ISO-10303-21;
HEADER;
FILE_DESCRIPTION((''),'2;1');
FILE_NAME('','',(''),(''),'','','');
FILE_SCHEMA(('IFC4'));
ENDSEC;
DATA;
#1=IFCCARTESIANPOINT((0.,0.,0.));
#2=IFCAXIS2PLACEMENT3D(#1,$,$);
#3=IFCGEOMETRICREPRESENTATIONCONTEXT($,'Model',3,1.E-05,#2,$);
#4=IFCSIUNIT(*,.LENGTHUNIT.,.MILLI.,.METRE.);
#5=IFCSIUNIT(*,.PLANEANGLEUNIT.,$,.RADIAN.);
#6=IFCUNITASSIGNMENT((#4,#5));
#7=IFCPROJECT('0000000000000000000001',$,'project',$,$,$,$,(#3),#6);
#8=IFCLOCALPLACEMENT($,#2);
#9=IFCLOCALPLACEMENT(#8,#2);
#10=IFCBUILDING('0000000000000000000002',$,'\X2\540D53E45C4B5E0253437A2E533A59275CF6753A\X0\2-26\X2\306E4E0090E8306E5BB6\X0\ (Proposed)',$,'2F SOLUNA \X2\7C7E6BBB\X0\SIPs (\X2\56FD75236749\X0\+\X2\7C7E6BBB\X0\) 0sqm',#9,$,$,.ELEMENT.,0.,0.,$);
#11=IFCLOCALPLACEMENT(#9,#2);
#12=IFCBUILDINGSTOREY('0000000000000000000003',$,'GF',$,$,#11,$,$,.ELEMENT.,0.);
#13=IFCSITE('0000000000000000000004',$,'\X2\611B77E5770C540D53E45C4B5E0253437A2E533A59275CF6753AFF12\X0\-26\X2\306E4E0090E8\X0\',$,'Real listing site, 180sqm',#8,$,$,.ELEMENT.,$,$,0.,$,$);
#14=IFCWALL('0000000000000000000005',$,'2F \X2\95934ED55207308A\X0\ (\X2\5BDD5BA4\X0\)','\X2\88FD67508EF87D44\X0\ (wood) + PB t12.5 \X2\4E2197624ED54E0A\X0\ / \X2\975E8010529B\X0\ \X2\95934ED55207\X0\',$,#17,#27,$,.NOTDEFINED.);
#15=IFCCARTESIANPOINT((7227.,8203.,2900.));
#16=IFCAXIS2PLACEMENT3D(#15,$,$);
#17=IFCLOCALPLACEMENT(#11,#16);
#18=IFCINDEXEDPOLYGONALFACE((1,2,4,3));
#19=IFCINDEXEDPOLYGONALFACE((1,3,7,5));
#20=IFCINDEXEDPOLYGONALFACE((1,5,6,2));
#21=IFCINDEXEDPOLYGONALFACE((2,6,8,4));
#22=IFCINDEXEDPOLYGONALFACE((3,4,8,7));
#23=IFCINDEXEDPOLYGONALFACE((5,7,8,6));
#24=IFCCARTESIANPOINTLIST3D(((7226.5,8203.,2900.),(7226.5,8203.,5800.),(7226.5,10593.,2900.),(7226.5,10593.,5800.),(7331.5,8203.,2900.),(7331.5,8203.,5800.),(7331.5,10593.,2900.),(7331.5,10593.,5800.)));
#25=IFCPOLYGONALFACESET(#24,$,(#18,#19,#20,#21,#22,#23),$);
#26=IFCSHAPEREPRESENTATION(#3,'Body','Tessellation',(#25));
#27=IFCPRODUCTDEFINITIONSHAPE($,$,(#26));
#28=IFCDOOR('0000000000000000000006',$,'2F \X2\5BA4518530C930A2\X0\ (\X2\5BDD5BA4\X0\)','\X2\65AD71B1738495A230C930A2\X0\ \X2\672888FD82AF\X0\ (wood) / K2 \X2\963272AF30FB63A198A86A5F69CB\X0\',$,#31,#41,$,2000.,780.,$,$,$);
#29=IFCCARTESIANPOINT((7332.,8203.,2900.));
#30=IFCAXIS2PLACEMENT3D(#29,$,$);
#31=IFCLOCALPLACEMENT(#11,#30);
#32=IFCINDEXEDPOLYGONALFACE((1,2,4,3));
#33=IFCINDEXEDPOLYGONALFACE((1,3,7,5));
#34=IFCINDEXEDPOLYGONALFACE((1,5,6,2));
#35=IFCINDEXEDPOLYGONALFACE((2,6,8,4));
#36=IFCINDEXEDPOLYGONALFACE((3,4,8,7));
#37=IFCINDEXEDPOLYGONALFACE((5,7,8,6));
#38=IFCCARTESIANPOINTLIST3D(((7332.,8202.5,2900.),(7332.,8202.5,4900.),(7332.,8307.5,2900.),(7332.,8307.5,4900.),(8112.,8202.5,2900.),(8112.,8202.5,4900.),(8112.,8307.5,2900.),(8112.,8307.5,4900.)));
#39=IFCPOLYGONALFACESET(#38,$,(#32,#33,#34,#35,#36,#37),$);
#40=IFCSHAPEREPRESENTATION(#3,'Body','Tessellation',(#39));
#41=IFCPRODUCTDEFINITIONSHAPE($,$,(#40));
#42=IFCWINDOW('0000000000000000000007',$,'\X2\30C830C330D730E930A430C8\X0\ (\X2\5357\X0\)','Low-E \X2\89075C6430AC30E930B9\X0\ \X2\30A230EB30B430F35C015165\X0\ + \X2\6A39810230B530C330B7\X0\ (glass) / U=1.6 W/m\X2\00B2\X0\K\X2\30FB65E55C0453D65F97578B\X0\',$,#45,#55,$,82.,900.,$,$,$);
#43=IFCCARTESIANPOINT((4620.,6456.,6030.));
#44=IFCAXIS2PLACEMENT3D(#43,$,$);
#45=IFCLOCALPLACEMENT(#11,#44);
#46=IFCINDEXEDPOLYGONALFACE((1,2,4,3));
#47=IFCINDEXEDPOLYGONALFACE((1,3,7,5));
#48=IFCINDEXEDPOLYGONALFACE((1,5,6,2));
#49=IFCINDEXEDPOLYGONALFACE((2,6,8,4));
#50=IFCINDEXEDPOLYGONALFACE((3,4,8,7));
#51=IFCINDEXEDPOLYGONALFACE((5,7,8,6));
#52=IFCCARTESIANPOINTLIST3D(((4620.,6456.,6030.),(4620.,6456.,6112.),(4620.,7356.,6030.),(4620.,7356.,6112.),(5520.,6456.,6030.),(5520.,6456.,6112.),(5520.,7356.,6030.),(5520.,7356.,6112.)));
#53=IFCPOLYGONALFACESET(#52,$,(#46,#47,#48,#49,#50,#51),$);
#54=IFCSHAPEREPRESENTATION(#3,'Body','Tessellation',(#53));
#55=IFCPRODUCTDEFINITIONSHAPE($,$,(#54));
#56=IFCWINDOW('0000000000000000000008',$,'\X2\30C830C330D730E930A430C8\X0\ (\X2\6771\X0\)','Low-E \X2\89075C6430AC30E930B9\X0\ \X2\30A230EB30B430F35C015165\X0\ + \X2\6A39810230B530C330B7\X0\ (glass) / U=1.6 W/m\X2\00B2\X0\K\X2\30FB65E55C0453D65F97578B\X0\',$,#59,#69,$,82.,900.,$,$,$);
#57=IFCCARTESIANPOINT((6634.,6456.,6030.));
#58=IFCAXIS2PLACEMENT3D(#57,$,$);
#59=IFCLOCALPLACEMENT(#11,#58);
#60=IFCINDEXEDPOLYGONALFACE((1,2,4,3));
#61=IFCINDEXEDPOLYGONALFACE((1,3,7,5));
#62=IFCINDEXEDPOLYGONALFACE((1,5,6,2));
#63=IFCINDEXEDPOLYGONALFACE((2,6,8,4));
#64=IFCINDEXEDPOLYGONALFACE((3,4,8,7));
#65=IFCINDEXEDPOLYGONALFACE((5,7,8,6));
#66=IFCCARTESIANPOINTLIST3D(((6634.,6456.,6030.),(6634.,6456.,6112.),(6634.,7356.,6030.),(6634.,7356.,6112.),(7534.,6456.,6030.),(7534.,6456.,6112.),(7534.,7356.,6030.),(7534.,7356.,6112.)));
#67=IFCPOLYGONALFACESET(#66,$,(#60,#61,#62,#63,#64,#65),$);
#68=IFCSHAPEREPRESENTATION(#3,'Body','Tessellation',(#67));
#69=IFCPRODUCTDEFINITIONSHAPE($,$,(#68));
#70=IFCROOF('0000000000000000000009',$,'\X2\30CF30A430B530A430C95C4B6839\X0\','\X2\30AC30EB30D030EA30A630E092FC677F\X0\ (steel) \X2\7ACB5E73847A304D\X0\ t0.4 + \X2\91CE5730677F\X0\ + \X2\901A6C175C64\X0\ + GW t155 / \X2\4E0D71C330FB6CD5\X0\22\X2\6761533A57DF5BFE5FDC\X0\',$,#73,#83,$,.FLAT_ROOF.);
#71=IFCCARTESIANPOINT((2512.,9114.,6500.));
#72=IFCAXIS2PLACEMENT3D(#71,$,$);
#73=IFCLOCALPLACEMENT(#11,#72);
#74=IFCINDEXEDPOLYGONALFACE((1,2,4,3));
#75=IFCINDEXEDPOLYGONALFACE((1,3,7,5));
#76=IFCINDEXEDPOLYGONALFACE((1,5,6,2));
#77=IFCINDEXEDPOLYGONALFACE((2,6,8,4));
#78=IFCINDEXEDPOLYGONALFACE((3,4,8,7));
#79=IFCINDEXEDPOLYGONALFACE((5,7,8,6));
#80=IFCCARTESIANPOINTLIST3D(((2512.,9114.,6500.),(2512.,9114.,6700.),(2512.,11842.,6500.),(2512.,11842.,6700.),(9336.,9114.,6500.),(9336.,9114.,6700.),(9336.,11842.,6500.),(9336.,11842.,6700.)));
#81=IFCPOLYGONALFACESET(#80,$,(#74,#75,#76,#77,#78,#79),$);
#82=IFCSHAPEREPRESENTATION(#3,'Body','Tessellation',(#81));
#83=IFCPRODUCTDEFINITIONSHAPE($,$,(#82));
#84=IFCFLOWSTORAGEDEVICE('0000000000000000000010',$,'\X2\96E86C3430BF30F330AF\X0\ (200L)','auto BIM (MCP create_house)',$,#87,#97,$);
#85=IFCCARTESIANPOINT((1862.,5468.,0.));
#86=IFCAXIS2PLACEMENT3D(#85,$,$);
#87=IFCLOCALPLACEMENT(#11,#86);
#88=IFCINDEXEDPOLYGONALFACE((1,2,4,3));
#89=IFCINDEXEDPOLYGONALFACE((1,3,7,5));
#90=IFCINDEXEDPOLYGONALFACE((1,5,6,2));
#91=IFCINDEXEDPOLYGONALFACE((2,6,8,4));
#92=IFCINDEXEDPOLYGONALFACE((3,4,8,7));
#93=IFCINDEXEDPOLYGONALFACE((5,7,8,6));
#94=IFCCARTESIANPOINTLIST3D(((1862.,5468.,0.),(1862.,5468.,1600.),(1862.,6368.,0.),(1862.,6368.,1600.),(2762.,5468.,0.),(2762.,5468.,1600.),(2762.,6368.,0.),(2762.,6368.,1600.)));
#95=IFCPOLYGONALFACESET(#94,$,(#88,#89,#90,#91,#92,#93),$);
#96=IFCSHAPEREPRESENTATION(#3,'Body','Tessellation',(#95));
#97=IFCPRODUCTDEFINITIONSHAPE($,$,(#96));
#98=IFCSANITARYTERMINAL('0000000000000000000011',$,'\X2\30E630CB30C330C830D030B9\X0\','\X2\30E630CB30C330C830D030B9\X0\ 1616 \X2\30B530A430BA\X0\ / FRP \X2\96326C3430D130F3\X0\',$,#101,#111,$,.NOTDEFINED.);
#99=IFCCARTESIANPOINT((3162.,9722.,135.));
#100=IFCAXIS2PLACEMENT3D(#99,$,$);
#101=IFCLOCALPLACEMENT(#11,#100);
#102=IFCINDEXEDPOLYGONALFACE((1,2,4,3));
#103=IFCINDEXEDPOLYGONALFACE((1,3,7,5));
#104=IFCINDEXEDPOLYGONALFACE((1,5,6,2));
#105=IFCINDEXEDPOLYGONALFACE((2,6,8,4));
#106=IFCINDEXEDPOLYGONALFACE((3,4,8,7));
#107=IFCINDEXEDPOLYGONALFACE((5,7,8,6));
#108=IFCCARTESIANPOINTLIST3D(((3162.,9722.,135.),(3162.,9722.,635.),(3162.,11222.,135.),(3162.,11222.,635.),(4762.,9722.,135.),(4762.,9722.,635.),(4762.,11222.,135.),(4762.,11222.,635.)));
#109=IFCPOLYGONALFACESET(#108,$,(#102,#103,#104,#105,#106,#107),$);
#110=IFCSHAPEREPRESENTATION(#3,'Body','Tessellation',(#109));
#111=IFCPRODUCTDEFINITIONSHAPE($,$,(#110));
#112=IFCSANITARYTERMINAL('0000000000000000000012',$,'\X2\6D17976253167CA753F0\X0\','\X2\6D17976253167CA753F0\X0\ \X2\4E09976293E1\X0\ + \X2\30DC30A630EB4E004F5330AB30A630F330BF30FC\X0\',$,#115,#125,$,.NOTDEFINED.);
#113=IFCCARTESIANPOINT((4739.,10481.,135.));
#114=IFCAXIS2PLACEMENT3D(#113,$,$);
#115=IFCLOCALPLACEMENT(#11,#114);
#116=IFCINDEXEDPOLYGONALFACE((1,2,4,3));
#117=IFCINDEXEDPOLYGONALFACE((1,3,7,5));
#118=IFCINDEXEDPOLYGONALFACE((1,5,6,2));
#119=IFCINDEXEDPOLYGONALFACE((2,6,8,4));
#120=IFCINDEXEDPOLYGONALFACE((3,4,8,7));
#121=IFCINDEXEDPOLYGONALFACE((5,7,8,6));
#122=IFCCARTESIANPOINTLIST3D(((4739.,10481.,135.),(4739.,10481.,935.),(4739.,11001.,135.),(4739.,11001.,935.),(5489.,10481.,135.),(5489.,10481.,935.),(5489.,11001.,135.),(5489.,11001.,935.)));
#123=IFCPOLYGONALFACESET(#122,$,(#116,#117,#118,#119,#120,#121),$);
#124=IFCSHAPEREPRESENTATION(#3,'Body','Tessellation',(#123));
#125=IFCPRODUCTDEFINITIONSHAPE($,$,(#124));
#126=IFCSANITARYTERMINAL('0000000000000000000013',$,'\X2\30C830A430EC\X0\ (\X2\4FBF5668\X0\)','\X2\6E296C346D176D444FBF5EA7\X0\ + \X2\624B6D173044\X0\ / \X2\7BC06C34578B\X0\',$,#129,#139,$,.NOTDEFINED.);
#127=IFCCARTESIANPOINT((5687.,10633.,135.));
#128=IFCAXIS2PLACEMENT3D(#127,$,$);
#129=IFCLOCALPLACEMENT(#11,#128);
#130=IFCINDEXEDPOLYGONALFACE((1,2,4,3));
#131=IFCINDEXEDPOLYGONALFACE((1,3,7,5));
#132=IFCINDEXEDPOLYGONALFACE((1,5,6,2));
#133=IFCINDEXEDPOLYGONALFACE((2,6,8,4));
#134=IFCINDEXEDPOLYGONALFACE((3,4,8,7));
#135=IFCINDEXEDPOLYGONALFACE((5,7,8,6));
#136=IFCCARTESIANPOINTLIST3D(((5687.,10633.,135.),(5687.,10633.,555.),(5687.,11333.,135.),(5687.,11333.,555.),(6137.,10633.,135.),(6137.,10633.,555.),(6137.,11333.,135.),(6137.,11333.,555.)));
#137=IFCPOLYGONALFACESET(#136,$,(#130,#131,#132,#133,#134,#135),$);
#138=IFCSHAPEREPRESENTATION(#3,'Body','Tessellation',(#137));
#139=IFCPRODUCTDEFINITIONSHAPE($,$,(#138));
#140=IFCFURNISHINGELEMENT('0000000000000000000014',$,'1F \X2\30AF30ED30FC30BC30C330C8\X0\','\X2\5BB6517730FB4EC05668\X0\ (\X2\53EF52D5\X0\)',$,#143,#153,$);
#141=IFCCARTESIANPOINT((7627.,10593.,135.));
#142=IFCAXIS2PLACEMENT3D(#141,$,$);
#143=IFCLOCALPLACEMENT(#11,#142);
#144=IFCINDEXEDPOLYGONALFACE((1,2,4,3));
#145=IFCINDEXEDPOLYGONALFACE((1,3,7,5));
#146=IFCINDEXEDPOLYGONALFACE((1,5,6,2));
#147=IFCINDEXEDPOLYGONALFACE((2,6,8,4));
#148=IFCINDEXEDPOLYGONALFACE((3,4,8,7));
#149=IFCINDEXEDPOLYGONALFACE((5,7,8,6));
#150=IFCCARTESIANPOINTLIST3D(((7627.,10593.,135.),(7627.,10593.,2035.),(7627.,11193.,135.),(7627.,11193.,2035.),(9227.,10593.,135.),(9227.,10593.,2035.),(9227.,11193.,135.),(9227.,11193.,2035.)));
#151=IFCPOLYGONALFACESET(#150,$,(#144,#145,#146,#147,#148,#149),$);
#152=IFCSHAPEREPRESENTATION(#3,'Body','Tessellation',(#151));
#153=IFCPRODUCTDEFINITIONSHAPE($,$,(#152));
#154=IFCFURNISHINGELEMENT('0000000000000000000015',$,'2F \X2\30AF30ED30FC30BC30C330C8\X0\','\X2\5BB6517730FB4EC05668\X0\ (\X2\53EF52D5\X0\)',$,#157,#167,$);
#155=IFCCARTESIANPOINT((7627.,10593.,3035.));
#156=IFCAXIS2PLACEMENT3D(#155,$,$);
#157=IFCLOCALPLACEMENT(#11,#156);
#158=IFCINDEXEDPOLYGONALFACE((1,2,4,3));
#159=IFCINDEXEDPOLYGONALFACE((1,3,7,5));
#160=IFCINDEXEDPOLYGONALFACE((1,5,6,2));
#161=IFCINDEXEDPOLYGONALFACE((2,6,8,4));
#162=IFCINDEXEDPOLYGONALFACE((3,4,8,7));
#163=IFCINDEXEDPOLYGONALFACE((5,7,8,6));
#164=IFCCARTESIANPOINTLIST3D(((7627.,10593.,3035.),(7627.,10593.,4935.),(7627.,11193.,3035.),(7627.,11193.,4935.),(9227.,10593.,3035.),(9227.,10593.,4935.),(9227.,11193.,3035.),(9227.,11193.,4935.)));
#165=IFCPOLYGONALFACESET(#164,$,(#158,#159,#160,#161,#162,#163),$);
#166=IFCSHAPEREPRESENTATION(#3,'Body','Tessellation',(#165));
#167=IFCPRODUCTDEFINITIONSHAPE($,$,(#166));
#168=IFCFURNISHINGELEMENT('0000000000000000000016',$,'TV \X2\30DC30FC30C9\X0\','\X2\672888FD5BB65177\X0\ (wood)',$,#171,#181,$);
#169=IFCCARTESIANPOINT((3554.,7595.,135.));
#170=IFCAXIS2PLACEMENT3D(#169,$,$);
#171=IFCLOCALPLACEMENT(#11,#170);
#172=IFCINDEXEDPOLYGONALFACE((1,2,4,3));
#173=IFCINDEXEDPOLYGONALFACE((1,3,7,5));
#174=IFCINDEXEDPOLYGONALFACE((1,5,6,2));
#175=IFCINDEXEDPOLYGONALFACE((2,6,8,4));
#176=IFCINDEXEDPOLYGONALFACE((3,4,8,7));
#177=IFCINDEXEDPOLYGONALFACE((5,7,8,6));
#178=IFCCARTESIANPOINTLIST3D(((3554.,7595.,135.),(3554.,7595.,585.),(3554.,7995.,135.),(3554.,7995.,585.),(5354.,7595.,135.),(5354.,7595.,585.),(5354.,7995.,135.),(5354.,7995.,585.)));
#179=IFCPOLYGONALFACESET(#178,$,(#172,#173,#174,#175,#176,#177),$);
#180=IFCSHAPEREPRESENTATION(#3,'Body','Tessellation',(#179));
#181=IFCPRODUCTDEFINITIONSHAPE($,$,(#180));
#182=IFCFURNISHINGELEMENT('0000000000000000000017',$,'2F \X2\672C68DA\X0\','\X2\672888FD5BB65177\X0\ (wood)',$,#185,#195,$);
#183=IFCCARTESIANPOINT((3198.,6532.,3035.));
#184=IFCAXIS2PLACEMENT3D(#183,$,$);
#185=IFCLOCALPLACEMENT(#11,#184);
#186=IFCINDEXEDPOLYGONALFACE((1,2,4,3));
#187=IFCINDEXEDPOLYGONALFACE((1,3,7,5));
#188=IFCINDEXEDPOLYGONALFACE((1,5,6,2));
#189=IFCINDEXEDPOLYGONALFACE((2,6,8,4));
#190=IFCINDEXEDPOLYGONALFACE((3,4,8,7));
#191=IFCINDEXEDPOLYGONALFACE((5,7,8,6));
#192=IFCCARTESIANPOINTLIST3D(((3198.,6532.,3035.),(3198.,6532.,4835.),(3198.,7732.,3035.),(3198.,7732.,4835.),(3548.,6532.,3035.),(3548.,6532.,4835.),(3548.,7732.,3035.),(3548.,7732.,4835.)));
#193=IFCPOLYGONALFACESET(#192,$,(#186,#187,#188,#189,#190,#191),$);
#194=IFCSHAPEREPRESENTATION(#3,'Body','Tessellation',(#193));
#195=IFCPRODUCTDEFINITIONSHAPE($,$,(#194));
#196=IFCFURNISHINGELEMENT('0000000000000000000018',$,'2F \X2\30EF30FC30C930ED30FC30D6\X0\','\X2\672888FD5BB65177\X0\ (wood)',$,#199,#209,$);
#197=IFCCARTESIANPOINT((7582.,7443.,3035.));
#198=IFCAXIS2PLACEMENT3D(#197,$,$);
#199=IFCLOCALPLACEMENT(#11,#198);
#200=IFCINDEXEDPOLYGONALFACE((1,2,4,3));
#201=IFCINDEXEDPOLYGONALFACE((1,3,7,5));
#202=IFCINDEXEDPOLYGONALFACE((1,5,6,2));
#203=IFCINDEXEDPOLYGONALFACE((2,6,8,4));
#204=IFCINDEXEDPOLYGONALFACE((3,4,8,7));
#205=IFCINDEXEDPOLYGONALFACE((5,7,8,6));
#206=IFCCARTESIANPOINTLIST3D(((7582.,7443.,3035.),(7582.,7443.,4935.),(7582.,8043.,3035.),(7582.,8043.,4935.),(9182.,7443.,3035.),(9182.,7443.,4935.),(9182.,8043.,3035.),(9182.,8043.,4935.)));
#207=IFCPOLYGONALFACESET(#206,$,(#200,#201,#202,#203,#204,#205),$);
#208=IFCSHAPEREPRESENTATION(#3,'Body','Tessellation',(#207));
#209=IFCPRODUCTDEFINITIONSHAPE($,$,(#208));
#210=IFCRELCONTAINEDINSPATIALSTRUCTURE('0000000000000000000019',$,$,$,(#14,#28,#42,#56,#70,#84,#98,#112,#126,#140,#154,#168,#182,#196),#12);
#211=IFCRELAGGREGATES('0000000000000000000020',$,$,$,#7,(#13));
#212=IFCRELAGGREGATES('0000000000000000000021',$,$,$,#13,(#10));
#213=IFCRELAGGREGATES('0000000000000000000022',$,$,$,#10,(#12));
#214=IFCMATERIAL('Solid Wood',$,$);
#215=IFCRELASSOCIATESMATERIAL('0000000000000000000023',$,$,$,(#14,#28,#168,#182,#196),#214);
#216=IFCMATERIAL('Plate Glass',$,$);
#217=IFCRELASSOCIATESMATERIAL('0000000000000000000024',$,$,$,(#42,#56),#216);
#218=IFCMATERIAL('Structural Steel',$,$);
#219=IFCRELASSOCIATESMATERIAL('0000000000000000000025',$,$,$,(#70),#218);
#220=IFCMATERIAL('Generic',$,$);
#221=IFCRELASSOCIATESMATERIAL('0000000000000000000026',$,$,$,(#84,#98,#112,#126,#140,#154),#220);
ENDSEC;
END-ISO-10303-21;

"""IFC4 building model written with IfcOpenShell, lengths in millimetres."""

from ifc_helpers import new_model, si_unit, frame, frame_2d, origin, place, context, project, spatial, rectangle, extrude, material, element, save


model = new_model("IFC4")

# Units and contexts
model_context = context("Model", 3, precision=1e-05, world=origin())
ifc_project = project(units=[si_unit("LENGTHUNIT", "METRE", prefix="MILLI"), si_unit("PLANEANGLEUNIT", "RADIAN")], contexts=[model_context])

# Site, building, storey
site_placement = place(None, origin())
site = spatial("IfcSite", under=ifc_project, at=site_placement, Name="愛知県名古屋市千種区大島町２-26の一部", ObjectType="Real listing site, 180sqm", CompositionType="ELEMENT", RefElevation=0.0)
building_placement = place(site_placement, origin())
building = spatial("IfcBuilding", under=site, at=building_placement, Name="名古屋市千種区大島町2-26の一部の家 (Proposed)", ObjectType="2F SOLUNA 籾殻SIPs (国産杉+籾殻) 0sqm", CompositionType="ELEMENT", ElevationOfRefHeight=0.0, ElevationOfTerrain=0.0)
storey_placement = place(building_placement, origin())
storey = spatial("IfcBuildingStorey", under=building, at=storey_placement, Name="GF", CompositionType="ELEMENT", Elevation=0.0)

# Shared definitions
ifc_material_1 = material(Name="Solid Wood")
ifc_material_2 = material(Name="Plate Glass")

# Wall
wall_1_placement = place(storey_placement, frame((7227.0, 8203.0, 2900.0)))
element("IfcWall", 1, at=wall_1_placement, inside=storey, material=ifc_material_1, Name="2F 間仕切り (寝室)", Description="製材軸組 (wood) + PB t12.5 両面仕上 / 非耐力 間仕切", PredefinedType="NOTDEFINED", context=model_context, shape_type="SweptSolid", body=[
    extrude(rectangle(XDim=105.0, YDim=2390.0, at=frame_2d((52.0, 1195.0))), frame((7227.0, 8203.0, 2900.0)), (0.0, 0.0, 1.0), 2900.0),
])

# Door
door_1_placement = place(storey_placement, frame((7332.0, 8203.0, 2900.0)))
element("IfcDoor", 2, at=door_1_placement, inside=storey, material=ifc_material_1, Name="2F 室内ドア (寝室)", Description="断熱玄関ドア 木製芯 (wood) / K2 防犯・採風機構", OverallHeight=2000.0, OverallWidth=780.0, context=model_context, shape_type="SweptSolid", body=[
    extrude(rectangle(XDim=780.0, YDim=105.0, at=frame_2d((390.0, 52.0))), frame((7332.0, 8203.0, 2900.0)), (0.0, 0.0, 1.0), 2000.0),
])

# Windows
window_1_placement = place(storey_placement, frame((4620.0, 6456.0, 6030.0)))
element("IfcWindow", 3, at=window_1_placement, inside=storey, material=ifc_material_2, Name="トップライト (南)", Description="Low-E 複層ガラス アルゴン封入 + 樹脂サッシ (glass) / U=1.6 W/m²K・日射取得型", OverallHeight=82.0, OverallWidth=900.0, context=model_context, shape_type="SweptSolid", body=[
    extrude(rectangle(XDim=900.0, YDim=900.0, at=frame_2d((450.0, 450.0))), frame((4620.0, 6456.0, 6030.0)), (0.0, 0.0, 1.0), 82.0),
])
window_2_placement = place(storey_placement, frame((6634.0, 6456.0, 6030.0)))
element("IfcWindow", 4, at=window_2_placement, inside=storey, material=ifc_material_2, Name="トップライト (東)", Description="Low-E 複層ガラス アルゴン封入 + 樹脂サッシ (glass) / U=1.6 W/m²K・日射取得型", OverallHeight=82.0, OverallWidth=900.0, context=model_context, shape_type="SweptSolid", body=[
    extrude(rectangle(XDim=900.0, YDim=900.0, at=frame_2d((450.0, 450.0))), frame((6634.0, 6456.0, 6030.0)), (0.0, 0.0, 1.0), 82.0),
])

# Roof
ifc_material_3 = material(Name="Structural Steel")
roof_placement = place(storey_placement, frame((2512.0, 9114.0, 6500.0)))
element("IfcRoof", 5, at=roof_placement, inside=storey, material=ifc_material_3, Name="ハイサイド屋根", Description="ガルバリウム鋼板 (steel) 立平葺き t0.4 + 野地板 + 通気層 + GW t155 / 不燃・法22条区域対応", PredefinedType="FLAT_ROOF", context=model_context, shape_type="SweptSolid", body=[
    extrude(rectangle(XDim=6824.0, YDim=2728.0, at=frame_2d((3412.0, 1364.0))), frame((2512.0, 9114.0, 6500.0)), (0.0, 0.0, 1.0), 200.0),
])

# Flow storage device
ifc_material_4 = material(Name="Generic")
flow_storage_device_placement = place(storey_placement, frame((1862.0, 5468.0, 0.0)))
element("IfcFlowStorageDevice", 6, at=flow_storage_device_placement, inside=storey, material=ifc_material_4, Name="雨水タンク (200L)", Description="auto BIM (MCP create_house)", context=model_context, shape_type="SweptSolid", body=[
    extrude(rectangle(XDim=900.0, YDim=900.0, at=frame_2d((450.0, 450.0))), frame((1862.0, 5468.0, 0.0)), (0.0, 0.0, 1.0), 1600.0),
])

# Sanitary terminals
sanitary_terminal_1_placement = place(storey_placement, frame((3162.0, 9722.0, 135.0)))
element("IfcSanitaryTerminal", 7, at=sanitary_terminal_1_placement, inside=storey, material=ifc_material_4, Name="ユニットバス", Description="ユニットバス 1616 サイズ / FRP 防水パン", PredefinedType="NOTDEFINED", context=model_context, shape_type="SweptSolid", body=[
    extrude(rectangle(XDim=1600.0, YDim=1500.0, at=frame_2d((800.0, 750.0))), frame((3162.0, 9722.0, 135.0)), (0.0, 0.0, 1.0), 500.0),
])
sanitary_terminal_2_placement = place(storey_placement, frame((4739.0, 10481.0, 135.0)))
element("IfcSanitaryTerminal", 8, at=sanitary_terminal_2_placement, inside=storey, material=ifc_material_4, Name="洗面化粧台", Description="洗面化粧台 三面鏡 + ボウル一体カウンター", PredefinedType="NOTDEFINED", context=model_context, shape_type="SweptSolid", body=[
    extrude(rectangle(XDim=750.0, YDim=520.0, at=frame_2d((375.0, 260.0))), frame((4739.0, 10481.0, 135.0)), (0.0, 0.0, 1.0), 800.0),
])
sanitary_terminal_3_placement = place(storey_placement, frame((5687.0, 10633.0, 135.0)))
element("IfcSanitaryTerminal", 9, at=sanitary_terminal_3_placement, inside=storey, material=ifc_material_4, Name="トイレ (便器)", Description="温水洗浄便座 + 手洗い / 節水型", PredefinedType="NOTDEFINED", context=model_context, shape_type="SweptSolid", body=[
    extrude(rectangle(XDim=450.0, YDim=700.0, at=frame_2d((225.0, 350.0))), frame((5687.0, 10633.0, 135.0)), (0.0, 0.0, 1.0), 420.0),
])

# Furnishing elements
furnishing_1_placement = place(storey_placement, frame((7627.0, 10593.0, 135.0)))
element("IfcFurnishingElement", 10, at=furnishing_1_placement, inside=storey, material=ifc_material_4, Name="1F クローゼット", Description="家具・什器 (可動)", context=model_context, shape_type="SweptSolid", body=[
    extrude(rectangle(XDim=1600.0, YDim=600.0, at=frame_2d((800.0, 300.0))), frame((7627.0, 10593.0, 135.0)), (0.0, 0.0, 1.0), 1900.0),
])
furnishing_2_placement = place(storey_placement, frame((7627.0, 10593.0, 3035.0)))
element("IfcFurnishingElement", 11, at=furnishing_2_placement, inside=storey, material=ifc_material_4, Name="2F クローゼット", Description="家具・什器 (可動)", context=model_context, shape_type="SweptSolid", body=[
    extrude(rectangle(XDim=1600.0, YDim=600.0, at=frame_2d((800.0, 300.0))), frame((7627.0, 10593.0, 3035.0)), (0.0, 0.0, 1.0), 1900.0),
])
furnishing_3_placement = place(storey_placement, frame((3554.0, 7595.0, 135.0)))
element("IfcFurnishingElement", 12, at=furnishing_3_placement, inside=storey, material=ifc_material_1, Name="TV ボード", Description="木製家具 (wood)", context=model_context, shape_type="SweptSolid", body=[
    extrude(rectangle(XDim=1800.0, YDim=400.0, at=frame_2d((900.0, 200.0))), frame((3554.0, 7595.0, 135.0)), (0.0, 0.0, 1.0), 450.0),
])
furnishing_4_placement = place(storey_placement, frame((3198.0, 6532.0, 3035.0)))
element("IfcFurnishingElement", 13, at=furnishing_4_placement, inside=storey, material=ifc_material_1, Name="2F 本棚", Description="木製家具 (wood)", context=model_context, shape_type="SweptSolid", body=[
    extrude(rectangle(XDim=350.0, YDim=1200.0, at=frame_2d((175.0, 600.0))), frame((3198.0, 6532.0, 3035.0)), (0.0, 0.0, 1.0), 1800.0),
])
furnishing_5_placement = place(storey_placement, frame((7582.0, 7443.0, 3035.0)))
element("IfcFurnishingElement", 14, at=furnishing_5_placement, inside=storey, material=ifc_material_1, Name="2F ワードローブ", Description="木製家具 (wood)", context=model_context, shape_type="SweptSolid", body=[
    extrude(rectangle(XDim=1600.0, YDim=600.0, at=frame_2d((800.0, 300.0))), frame((7582.0, 7443.0, 3035.0)), (0.0, 0.0, 1.0), 1900.0),
])

save(model, "model.ifc")
